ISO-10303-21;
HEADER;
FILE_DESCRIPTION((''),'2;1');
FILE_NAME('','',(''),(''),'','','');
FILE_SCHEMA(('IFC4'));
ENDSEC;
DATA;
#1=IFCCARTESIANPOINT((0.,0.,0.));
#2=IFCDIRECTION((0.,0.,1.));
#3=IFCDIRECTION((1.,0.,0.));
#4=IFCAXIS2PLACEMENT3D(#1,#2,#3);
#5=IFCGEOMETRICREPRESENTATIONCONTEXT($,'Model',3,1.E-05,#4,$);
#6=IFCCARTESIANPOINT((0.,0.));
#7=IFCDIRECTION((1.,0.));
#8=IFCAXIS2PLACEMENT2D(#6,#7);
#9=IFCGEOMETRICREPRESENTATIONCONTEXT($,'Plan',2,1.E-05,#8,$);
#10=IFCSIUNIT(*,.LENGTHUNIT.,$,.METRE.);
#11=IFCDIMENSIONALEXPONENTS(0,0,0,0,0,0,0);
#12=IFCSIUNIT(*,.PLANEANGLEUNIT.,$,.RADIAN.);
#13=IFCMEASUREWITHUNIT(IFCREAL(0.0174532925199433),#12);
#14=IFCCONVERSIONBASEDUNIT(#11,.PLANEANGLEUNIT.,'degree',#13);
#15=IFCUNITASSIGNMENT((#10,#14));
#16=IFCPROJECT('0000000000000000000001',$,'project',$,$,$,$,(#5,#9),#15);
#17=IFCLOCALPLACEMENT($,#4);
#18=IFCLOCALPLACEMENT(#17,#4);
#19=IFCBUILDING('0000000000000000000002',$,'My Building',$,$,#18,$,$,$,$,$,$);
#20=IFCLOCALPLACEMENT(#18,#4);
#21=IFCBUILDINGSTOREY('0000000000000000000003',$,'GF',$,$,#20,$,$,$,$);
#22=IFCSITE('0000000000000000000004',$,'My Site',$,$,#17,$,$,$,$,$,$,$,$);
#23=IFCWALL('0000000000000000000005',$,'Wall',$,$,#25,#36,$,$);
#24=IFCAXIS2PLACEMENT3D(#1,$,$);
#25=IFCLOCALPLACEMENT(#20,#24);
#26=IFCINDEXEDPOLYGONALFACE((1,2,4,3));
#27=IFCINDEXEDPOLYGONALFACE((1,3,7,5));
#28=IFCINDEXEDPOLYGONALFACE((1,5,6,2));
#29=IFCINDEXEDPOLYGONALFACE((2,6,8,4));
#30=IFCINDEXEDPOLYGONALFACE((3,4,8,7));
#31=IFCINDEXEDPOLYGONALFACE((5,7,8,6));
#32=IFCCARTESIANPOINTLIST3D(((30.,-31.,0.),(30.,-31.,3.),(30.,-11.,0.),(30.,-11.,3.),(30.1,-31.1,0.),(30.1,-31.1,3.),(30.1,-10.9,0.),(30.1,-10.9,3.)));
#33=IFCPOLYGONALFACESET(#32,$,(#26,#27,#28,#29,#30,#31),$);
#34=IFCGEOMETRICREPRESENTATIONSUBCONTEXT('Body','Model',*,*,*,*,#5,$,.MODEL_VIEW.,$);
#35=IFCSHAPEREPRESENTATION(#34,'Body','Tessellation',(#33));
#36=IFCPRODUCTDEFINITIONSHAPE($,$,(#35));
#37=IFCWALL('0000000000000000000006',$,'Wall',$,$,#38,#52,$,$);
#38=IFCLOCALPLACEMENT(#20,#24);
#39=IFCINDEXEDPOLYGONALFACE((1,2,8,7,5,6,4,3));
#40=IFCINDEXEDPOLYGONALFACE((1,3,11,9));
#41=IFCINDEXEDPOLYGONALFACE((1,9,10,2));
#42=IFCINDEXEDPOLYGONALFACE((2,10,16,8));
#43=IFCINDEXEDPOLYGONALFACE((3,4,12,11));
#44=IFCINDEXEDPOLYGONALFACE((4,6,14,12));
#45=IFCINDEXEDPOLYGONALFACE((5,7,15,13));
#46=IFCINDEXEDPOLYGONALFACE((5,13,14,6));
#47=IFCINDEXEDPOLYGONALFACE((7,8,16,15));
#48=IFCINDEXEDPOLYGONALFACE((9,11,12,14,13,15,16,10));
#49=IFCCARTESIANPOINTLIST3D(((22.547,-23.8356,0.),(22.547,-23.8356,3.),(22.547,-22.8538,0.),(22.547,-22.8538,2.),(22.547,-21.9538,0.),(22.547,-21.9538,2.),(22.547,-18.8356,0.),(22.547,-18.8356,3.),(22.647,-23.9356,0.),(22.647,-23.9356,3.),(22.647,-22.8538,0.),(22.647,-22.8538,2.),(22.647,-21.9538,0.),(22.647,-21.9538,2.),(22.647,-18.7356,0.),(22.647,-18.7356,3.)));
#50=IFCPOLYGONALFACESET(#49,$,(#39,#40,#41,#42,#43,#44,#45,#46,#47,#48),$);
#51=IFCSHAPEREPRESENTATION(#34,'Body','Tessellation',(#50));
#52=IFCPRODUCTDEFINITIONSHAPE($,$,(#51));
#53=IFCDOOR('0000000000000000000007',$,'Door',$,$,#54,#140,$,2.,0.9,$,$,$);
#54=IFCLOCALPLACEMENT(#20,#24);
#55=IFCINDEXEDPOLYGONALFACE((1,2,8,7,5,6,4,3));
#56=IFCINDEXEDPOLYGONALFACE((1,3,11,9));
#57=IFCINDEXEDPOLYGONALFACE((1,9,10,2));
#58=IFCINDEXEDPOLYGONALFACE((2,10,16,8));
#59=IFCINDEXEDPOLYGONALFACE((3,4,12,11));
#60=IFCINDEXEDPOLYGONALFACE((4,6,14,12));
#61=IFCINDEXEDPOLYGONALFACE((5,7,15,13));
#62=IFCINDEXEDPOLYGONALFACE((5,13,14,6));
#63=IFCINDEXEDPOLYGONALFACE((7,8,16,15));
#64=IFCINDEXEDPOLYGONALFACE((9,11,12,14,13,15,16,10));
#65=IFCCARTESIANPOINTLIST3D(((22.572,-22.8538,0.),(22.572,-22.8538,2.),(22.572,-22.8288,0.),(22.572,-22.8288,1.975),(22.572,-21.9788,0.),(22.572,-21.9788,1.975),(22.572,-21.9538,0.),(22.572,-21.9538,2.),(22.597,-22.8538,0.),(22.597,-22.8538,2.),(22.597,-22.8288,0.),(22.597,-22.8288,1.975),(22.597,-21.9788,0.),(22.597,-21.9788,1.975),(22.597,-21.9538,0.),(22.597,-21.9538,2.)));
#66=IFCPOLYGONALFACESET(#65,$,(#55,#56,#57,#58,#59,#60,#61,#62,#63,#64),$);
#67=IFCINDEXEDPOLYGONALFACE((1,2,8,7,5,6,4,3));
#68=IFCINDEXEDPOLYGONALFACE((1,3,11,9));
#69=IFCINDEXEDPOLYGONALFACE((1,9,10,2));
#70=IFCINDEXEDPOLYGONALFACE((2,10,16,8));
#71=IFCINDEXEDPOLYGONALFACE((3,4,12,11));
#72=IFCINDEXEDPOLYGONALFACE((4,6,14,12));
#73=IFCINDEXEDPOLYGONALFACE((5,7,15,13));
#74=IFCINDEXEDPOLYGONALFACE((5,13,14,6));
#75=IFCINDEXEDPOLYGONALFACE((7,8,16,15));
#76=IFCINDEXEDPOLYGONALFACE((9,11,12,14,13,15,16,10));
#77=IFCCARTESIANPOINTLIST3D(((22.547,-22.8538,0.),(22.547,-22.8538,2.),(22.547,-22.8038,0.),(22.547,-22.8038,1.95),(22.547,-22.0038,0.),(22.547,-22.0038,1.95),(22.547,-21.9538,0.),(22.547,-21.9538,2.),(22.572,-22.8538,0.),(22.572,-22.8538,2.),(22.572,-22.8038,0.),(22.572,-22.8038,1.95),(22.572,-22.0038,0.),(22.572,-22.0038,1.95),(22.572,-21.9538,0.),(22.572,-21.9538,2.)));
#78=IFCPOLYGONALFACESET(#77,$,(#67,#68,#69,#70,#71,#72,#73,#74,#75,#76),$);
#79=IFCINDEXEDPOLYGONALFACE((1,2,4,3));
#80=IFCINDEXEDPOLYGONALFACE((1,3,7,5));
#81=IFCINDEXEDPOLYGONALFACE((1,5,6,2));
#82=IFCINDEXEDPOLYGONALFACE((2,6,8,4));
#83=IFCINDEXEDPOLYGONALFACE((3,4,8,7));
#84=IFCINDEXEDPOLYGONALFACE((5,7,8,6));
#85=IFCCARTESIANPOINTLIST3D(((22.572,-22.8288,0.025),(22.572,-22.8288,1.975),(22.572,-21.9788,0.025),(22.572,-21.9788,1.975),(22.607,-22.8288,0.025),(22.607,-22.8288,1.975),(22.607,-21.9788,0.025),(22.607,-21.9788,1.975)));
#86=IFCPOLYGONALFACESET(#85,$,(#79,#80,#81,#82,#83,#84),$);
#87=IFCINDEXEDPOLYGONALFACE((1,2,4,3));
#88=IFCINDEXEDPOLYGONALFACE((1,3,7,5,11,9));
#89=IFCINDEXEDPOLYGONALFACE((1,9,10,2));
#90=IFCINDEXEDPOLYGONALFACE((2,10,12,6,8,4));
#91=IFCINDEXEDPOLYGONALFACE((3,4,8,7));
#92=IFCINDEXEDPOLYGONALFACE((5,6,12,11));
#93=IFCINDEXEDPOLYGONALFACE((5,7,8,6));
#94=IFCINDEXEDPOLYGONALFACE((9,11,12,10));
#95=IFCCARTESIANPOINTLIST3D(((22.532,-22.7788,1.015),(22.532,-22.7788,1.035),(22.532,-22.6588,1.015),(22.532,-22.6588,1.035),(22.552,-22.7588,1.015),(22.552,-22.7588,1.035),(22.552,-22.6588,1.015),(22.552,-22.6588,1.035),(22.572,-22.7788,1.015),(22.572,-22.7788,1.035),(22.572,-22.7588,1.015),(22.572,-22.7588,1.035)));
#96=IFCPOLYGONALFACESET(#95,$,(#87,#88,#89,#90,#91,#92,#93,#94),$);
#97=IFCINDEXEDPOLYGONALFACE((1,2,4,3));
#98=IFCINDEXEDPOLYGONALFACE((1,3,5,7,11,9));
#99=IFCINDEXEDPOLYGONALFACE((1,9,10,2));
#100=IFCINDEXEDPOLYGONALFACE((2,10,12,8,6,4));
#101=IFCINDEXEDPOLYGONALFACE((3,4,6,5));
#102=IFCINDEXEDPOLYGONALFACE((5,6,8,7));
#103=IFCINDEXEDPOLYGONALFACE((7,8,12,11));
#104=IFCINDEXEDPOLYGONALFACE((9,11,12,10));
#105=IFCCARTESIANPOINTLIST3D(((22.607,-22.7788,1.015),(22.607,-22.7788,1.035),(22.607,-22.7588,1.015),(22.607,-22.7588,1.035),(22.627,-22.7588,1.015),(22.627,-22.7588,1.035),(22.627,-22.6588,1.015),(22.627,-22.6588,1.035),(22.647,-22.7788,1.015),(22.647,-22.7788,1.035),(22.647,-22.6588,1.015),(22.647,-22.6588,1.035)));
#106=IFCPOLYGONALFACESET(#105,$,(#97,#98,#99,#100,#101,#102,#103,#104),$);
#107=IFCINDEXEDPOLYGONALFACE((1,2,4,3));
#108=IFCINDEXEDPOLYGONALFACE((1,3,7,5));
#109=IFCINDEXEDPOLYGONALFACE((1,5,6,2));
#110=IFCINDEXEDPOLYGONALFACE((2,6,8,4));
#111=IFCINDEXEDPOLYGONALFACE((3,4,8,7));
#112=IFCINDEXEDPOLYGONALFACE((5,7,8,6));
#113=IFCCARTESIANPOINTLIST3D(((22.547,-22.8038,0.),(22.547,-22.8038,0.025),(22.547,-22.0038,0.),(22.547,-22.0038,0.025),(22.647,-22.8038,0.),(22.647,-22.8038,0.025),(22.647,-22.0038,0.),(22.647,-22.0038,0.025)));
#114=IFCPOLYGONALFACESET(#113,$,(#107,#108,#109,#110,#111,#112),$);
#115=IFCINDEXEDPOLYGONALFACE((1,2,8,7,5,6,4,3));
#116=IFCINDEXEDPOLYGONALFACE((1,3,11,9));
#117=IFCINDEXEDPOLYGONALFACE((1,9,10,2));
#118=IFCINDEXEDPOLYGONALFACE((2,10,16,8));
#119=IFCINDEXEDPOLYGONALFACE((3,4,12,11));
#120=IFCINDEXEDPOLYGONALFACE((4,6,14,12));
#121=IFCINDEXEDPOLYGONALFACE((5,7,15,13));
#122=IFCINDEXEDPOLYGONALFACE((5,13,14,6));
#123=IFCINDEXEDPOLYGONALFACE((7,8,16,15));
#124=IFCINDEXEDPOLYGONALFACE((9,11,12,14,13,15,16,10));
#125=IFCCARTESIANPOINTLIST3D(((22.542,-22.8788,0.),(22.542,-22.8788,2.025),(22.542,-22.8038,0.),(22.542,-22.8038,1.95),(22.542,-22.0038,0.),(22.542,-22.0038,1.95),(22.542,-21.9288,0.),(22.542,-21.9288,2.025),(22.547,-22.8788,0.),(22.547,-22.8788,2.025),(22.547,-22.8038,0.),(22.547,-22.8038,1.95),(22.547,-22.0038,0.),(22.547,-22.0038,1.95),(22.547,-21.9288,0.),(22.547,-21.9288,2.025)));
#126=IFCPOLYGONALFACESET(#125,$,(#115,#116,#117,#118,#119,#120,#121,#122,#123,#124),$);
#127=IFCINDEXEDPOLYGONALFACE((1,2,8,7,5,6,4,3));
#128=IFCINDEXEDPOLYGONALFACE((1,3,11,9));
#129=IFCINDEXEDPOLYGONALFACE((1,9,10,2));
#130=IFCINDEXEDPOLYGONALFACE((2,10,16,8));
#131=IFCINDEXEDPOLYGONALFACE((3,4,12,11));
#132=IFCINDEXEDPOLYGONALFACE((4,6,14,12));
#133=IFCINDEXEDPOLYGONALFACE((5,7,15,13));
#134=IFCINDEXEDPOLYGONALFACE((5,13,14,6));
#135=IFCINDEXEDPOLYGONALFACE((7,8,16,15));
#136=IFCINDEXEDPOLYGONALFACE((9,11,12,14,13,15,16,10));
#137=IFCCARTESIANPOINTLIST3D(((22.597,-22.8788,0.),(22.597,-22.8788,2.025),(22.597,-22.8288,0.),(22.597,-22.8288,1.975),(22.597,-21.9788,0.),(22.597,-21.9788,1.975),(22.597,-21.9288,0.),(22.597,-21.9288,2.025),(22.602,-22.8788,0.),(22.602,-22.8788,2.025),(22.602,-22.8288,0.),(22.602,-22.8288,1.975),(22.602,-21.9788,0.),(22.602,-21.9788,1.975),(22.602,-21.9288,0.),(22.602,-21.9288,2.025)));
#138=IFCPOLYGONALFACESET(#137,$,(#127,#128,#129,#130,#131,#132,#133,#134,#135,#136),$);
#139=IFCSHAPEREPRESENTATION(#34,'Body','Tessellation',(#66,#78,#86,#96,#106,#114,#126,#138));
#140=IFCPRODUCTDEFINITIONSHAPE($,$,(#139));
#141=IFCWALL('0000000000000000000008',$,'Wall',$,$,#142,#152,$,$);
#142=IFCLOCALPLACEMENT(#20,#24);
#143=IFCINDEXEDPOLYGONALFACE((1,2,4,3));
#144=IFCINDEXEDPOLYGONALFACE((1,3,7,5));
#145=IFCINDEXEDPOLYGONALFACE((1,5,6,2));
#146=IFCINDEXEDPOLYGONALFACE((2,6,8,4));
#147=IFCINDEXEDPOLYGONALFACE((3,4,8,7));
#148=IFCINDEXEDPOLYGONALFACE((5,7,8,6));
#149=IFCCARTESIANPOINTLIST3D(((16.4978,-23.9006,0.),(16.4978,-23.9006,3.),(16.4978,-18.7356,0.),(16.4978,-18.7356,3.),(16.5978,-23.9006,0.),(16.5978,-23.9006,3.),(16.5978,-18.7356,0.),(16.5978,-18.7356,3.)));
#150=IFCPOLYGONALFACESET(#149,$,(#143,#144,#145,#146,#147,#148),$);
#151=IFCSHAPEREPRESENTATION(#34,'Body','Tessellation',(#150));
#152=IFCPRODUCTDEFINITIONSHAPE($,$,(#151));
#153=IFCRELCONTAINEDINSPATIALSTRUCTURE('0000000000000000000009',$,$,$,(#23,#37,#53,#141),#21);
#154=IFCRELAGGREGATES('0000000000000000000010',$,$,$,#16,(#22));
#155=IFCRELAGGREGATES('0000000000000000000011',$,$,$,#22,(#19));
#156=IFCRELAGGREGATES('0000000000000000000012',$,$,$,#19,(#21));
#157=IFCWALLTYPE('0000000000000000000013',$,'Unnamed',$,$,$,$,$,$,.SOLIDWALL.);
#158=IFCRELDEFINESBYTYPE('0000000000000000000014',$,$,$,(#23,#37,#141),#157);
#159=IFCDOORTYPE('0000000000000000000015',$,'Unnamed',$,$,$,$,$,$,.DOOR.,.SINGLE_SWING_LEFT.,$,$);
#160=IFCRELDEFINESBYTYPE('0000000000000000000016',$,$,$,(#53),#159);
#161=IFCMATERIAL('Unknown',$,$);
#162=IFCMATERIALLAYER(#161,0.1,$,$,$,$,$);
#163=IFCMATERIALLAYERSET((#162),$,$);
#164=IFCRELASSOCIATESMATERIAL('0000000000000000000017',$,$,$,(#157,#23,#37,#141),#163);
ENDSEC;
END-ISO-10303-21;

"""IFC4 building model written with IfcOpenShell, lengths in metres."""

from ifc_helpers import new_model, entity, si_unit, converted_unit, frame, origin_with_axes, origin_2d_with_axis, place, context, subcontext, project, spatial, line, indexed_curve, outline, extrude, shape, source, transform, mapped, material, layer, layer_set, layer_usage, type_object, type_shapes, element, fill, save


model = new_model("IFC4")

# Units and contexts
model_context = context("Model", 3, precision=1e-05, world=origin_with_axes())
plan_context = context("Plan", 2, precision=1e-05, world=origin_2d_with_axis())
body_context_1 = subcontext(model_context, "Body", "Model", "MODEL_VIEW")
body_context_2 = subcontext(plan_context, "Body", "Plan", "PLAN_VIEW")
ifc_project = project(units=[si_unit("LENGTHUNIT", "METRE"), converted_unit("PLANEANGLEUNIT", "degree", entity("IfcReal", 0.0174532925199433), si_unit("PLANEANGLEUNIT", "RADIAN"), dimensions=[0, 0, 0, 0, 0, 0, 0])], contexts=[model_context, plan_context])

# Site, building, storey
site_placement = place(None, origin_with_axes())
site = spatial("IfcSite", under=ifc_project, at=site_placement, Name="My Site")
building_placement = place(site_placement, origin_with_axes())
building = spatial("IfcBuilding", under=site, at=building_placement, Name="My Building")
storey_placement = place(building_placement, origin_with_axes())
storey = spatial("IfcBuildingStorey", under=building, at=storey_placement, Name="GF")

# Wall
ifc_material = material(Name="Unknown")
ifc_layer = layer(ifc_material, 0.1)
ifc_layer_set = layer_set([ifc_layer])
ifc_layer_usage_1 = layer_usage(ifc_layer_set, "AXIS2", "POSITIVE", 0.0)
wall_type = type_object("IfcWallType", Name="Unnamed", PredefinedType="SOLIDWALL", material=ifc_layer_set)
wall_1_placement = place(storey_placement, frame((30.0, -11.0, 0.0), z_axis=(0.0, 0.0, 1.0), x_axis=(0.0, -1.0, 0.0)))
element("IfcWall", 1, at=wall_1_placement, inside=storey, type_object=wall_type, material=ifc_layer_usage_1, Name="Wall", context=body_context_1, shape_type="SweptSolid", body=[
    extrude(outline(indexed_curve([(0.0, 0.0), (-0.1, 0.1), (20.1, 0.1), (20.0, 0.0)], segments=[line(1, 2, 3, 4, 1)])), origin_with_axes(), (0.0, 0.0, 1.0), 3.0),
])

# Wall, opening, door
ifc_layer_usage_2 = layer_usage(ifc_layer_set, "AXIS2", "POSITIVE", 0.0)
wall_2_placement = place(storey_placement, frame((22.547, -18.8356, 0.0), z_axis=(0.0, 0.0, 1.0), x_axis=(0.0, -1.0, 0.0)))
wall_2 = element("IfcWall", 2, at=wall_2_placement, inside=storey, type_object=wall_type, material=ifc_layer_usage_2, Name="Wall", context=body_context_1, shape_type="SweptSolid", body=[
    extrude(outline(indexed_curve([(0.0, 0.0), (-0.1, 0.1), (5.1, 0.1), (5.0, 0.0)], segments=[line(1, 2, 3, 4, 1)])), origin_with_axes(), (0.0, 0.0, 1.0), 3.0),
])
shared_shape_1 = source(origin_with_axes(), body_context_1, "Body", "SweptSolid", [
    extrude(outline(indexed_curve([(0.0, 0.0), (0.9, 0.0), (0.9, 2.0), (0.0, 2.0)], segments=[line(1, 2, 3, 4, 1)])), frame((0.0, -0.6, 0.0), z_axis=(0.0, -1.0, 0.0), x_axis=(1.0, 0.0, 0.0)), (0.0, 0.0, -1.0), 1.2),
])
opening_1_placement = place(wall_2_placement, frame((3.1182, 0.0, 0.0), z_axis=(0.0, 0.0, 1.0), x_axis=(1.0, 0.0, 0.0)))
opening_1 = element("IfcOpeningElement", 3, at=opening_1_placement, cuts=wall_2, PredefinedType="OPENING", context=body_context_1, shape_type="MappedRepresentation", body=[
    mapped(shared_shape_1, transform((0.0, 0.0, 0.0), x_axis=(1.0, 0.0, 0.0), y_axis=(0.0, 1.0, 0.0), z_axis=(0.0, 0.0, 1.0), scale=1.0)),
])
door_type = type_object("IfcDoorType", Name="Unnamed", OperationType="SINGLE_SWING_LEFT", PredefinedType="DOOR")
shared_shape_2 = source(origin_with_axes(), body_context_1, "Body", "SweptSolid", [
    extrude(outline(indexed_curve([(0.0, 0.0), (0.0, 2.0), (0.9, 2.0), (0.9, 0.0), (0.875, 0.0), (0.875, 1.975), (0.025, 1.975), (0.025, 0.0)], segments=[line(1, 2, 3, 4, 5, 6, 7, 8, 1)])), frame((0.0, 0.025, 0.0), z_axis=(0.0, -1.0, 0.0), x_axis=(1.0, 0.0, 0.0)), (0.0, 0.0, -1.0), 0.025),
    extrude(outline(indexed_curve([(0.0, 0.0), (0.0, 2.0), (0.9, 2.0), (0.9, 0.0), (0.85, 0.0), (0.85, 1.95), (0.05, 1.95), (0.05, 0.0)], segments=[line(1, 2, 3, 4, 5, 6, 7, 8, 1)])), frame((0.0, 0.0, 0.0), z_axis=(0.0, -1.0, 0.0), x_axis=(1.0, 0.0, 0.0)), (0.0, 0.0, -1.0), 0.025),
    extrude(outline(indexed_curve([(0.0, 0.0), (0.85, 0.0), (0.85, 0.035), (0.0, 0.035)], segments=[line(1, 2, 3, 4, 1)])), frame((0.025, 0.025, 0.025), z_axis=(0.0, 0.0, 1.0), x_axis=(1.0, 0.0, 0.0)), (0.0, 0.0, 1.0), 1.95),
    extrude(outline(indexed_curve([(0.0, 0.0), (0.0, -0.04), (-0.12, -0.04), (-0.12, -0.02), (-0.02, -0.02), (-0.02, 0.0)], segments=[line(1, 2, 3, 4, 5, 6, 1)])), frame((0.825, 0.025, 1.015), z_axis=(0.0, 0.0, 1.0), x_axis=(1.0, 0.0, 0.0)), (0.0, 0.0, 1.0), 0.02),
    extrude(outline(indexed_curve([(0.0, 0.0), (0.0, 0.04), (-0.12, 0.04), (-0.12, 0.02), (-0.02, 0.02), (-0.02, 0.0)], segments=[line(1, 2, 3, 4, 5, 6, 1)])), frame((0.825, 0.06, 1.015), z_axis=(0.0, 0.0, 1.0), x_axis=(1.0, 0.0, 0.0)), (0.0, 0.0, 1.0), 0.02),
    extrude(outline(indexed_curve([(0.0, 0.0), (0.8, 0.0), (0.8, 0.1), (0.0, 0.1)], segments=[line(1, 2, 3, 4, 1)])), frame((0.05, 0.0, 0.0), z_axis=(0.0, 0.0, 1.0), x_axis=(1.0, 0.0, 0.0)), (0.0, 0.0, 1.0), 0.025),
    extrude(outline(indexed_curve([(0.0, 0.0), (0.0, 2.025), (0.95, 2.025), (0.95, 0.0), (0.875, 0.0), (0.875, 1.95), (0.075, 1.95), (0.075, 0.0)], segments=[line(1, 2, 3, 4, 5, 6, 7, 8, 1)])), frame((-0.025, -0.005, 0.0), z_axis=(0.0, -1.0, 0.0), x_axis=(1.0, 0.0, 0.0)), (0.0, 0.0, -1.0), 0.005),
    extrude(outline(indexed_curve([(0.0, 0.0), (0.0, 2.025), (0.95, 2.025), (0.95, 0.0), (0.9, 0.0), (0.9, 1.975), (0.05, 1.975), (0.05, 0.0)], segments=[line(1, 2, 3, 4, 5, 6, 7, 8, 1)])), frame((-0.025, 0.05, 0.0), z_axis=(0.0, -1.0, 0.0), x_axis=(1.0, 0.0, 0.0)), (0.0, 0.0, -1.0), 0.005),
])
shared_shape_3 = source(origin_with_axes(), body_context_2, "Body", "Curve2D", [
    entity("IfcIndexedPolyCurve", entity("IfcCartesianPointList2D", [[0.0, 0.0], [0.0, 0.05], [0.025, 0.05], [0.025, 0.025], [0.05, 0.025], [0.05, 0.0]]), [entity("IfcLineIndex", [1, 2, 3, 4, 5, 6, 1])]),
    entity("IfcIndexedPolyCurve", entity("IfcCartesianPointList2D", [[0.9, 0.0], [0.9, 0.05], [0.875, 0.05], [0.875, 0.025], [0.85, 0.025], [0.85, 0.0]]), [entity("IfcLineIndex", [1, 2, 3, 4, 5, 6, 1])]),
    entity("IfcTrimmedCurve", entity("IfcEllipse", entity("IfcAxis2Placement2D", entity("IfcCartesianPoint", [0.06, 0.05]), entity("IfcDirection", [1.0, 0.0])), 0.815, 0.85), [entity("IfcCartesianPoint", [0.875, 0.05])], [entity("IfcCartesianPoint", [0.06, 0.9])], True, "CARTESIAN"),
    entity("IfcIndexedPolyCurve", entity("IfcCartesianPointList2D", [[0.025, 0.05], [0.06, 0.05], [0.06, 0.9], [0.025, 0.9]]), [entity("IfcLineIndex", [1, 2, 3, 4, 1])]),
])
type_shapes(door_type, [shared_shape_2, shared_shape_3])
door_1_placement = place(opening_1_placement, frame((0.0, 0.0, 0.0), z_axis=(0.0, 0.0, 1.0), x_axis=(1.0, 0.0, 0.0)))
door_1 = element("IfcDoor", 4, at=door_1_placement, inside=storey, type_object=door_type, Name="Door", OverallHeight=2.0, OverallWidth=0.9, shapes=[
    shape(body_context_1, "Body", "MappedRepresentation", [mapped(shared_shape_2, transform((0.0, 0.0, 0.0), x_axis=(1.0, 0.0, 0.0), y_axis=(0.0, 1.0, 0.0), z_axis=(0.0, 0.0, 1.0), scale=1.0))]),
    shape(body_context_2, "Body", "MappedRepresentation", [mapped(shared_shape_3, transform((0.0, 0.0, 0.0), x_axis=(1.0, 0.0, 0.0), y_axis=(0.0, 1.0, 0.0), z_axis=(0.0, 0.0, 1.0), scale=1.0))]),
])
fill(opening_1, door_1)

# Wall
ifc_layer_usage_3 = layer_usage(ifc_layer_set, "AXIS2", "POSITIVE", 0.0)
wall_3_placement = place(storey_placement, frame((16.4978, -18.7356, 0.0), z_axis=(0.0, 0.0, 1.0), x_axis=(0.0, -1.0, 0.0)))
element("IfcWall", 5, at=wall_3_placement, inside=storey, type_object=wall_type, material=ifc_layer_usage_3, Name="Wall", context=body_context_1, shape_type="SweptSolid", body=[
    extrude(outline(indexed_curve([(0.0, 0.0), (0.0, 0.1), (5.1651, 0.1), (5.1651, 0.0)], segments=[line(1, 2, 3, 4, 1)])), origin_with_axes(), (0.0, 0.0, 1.0), 3.0),
])

save(model, "model.ifc")
